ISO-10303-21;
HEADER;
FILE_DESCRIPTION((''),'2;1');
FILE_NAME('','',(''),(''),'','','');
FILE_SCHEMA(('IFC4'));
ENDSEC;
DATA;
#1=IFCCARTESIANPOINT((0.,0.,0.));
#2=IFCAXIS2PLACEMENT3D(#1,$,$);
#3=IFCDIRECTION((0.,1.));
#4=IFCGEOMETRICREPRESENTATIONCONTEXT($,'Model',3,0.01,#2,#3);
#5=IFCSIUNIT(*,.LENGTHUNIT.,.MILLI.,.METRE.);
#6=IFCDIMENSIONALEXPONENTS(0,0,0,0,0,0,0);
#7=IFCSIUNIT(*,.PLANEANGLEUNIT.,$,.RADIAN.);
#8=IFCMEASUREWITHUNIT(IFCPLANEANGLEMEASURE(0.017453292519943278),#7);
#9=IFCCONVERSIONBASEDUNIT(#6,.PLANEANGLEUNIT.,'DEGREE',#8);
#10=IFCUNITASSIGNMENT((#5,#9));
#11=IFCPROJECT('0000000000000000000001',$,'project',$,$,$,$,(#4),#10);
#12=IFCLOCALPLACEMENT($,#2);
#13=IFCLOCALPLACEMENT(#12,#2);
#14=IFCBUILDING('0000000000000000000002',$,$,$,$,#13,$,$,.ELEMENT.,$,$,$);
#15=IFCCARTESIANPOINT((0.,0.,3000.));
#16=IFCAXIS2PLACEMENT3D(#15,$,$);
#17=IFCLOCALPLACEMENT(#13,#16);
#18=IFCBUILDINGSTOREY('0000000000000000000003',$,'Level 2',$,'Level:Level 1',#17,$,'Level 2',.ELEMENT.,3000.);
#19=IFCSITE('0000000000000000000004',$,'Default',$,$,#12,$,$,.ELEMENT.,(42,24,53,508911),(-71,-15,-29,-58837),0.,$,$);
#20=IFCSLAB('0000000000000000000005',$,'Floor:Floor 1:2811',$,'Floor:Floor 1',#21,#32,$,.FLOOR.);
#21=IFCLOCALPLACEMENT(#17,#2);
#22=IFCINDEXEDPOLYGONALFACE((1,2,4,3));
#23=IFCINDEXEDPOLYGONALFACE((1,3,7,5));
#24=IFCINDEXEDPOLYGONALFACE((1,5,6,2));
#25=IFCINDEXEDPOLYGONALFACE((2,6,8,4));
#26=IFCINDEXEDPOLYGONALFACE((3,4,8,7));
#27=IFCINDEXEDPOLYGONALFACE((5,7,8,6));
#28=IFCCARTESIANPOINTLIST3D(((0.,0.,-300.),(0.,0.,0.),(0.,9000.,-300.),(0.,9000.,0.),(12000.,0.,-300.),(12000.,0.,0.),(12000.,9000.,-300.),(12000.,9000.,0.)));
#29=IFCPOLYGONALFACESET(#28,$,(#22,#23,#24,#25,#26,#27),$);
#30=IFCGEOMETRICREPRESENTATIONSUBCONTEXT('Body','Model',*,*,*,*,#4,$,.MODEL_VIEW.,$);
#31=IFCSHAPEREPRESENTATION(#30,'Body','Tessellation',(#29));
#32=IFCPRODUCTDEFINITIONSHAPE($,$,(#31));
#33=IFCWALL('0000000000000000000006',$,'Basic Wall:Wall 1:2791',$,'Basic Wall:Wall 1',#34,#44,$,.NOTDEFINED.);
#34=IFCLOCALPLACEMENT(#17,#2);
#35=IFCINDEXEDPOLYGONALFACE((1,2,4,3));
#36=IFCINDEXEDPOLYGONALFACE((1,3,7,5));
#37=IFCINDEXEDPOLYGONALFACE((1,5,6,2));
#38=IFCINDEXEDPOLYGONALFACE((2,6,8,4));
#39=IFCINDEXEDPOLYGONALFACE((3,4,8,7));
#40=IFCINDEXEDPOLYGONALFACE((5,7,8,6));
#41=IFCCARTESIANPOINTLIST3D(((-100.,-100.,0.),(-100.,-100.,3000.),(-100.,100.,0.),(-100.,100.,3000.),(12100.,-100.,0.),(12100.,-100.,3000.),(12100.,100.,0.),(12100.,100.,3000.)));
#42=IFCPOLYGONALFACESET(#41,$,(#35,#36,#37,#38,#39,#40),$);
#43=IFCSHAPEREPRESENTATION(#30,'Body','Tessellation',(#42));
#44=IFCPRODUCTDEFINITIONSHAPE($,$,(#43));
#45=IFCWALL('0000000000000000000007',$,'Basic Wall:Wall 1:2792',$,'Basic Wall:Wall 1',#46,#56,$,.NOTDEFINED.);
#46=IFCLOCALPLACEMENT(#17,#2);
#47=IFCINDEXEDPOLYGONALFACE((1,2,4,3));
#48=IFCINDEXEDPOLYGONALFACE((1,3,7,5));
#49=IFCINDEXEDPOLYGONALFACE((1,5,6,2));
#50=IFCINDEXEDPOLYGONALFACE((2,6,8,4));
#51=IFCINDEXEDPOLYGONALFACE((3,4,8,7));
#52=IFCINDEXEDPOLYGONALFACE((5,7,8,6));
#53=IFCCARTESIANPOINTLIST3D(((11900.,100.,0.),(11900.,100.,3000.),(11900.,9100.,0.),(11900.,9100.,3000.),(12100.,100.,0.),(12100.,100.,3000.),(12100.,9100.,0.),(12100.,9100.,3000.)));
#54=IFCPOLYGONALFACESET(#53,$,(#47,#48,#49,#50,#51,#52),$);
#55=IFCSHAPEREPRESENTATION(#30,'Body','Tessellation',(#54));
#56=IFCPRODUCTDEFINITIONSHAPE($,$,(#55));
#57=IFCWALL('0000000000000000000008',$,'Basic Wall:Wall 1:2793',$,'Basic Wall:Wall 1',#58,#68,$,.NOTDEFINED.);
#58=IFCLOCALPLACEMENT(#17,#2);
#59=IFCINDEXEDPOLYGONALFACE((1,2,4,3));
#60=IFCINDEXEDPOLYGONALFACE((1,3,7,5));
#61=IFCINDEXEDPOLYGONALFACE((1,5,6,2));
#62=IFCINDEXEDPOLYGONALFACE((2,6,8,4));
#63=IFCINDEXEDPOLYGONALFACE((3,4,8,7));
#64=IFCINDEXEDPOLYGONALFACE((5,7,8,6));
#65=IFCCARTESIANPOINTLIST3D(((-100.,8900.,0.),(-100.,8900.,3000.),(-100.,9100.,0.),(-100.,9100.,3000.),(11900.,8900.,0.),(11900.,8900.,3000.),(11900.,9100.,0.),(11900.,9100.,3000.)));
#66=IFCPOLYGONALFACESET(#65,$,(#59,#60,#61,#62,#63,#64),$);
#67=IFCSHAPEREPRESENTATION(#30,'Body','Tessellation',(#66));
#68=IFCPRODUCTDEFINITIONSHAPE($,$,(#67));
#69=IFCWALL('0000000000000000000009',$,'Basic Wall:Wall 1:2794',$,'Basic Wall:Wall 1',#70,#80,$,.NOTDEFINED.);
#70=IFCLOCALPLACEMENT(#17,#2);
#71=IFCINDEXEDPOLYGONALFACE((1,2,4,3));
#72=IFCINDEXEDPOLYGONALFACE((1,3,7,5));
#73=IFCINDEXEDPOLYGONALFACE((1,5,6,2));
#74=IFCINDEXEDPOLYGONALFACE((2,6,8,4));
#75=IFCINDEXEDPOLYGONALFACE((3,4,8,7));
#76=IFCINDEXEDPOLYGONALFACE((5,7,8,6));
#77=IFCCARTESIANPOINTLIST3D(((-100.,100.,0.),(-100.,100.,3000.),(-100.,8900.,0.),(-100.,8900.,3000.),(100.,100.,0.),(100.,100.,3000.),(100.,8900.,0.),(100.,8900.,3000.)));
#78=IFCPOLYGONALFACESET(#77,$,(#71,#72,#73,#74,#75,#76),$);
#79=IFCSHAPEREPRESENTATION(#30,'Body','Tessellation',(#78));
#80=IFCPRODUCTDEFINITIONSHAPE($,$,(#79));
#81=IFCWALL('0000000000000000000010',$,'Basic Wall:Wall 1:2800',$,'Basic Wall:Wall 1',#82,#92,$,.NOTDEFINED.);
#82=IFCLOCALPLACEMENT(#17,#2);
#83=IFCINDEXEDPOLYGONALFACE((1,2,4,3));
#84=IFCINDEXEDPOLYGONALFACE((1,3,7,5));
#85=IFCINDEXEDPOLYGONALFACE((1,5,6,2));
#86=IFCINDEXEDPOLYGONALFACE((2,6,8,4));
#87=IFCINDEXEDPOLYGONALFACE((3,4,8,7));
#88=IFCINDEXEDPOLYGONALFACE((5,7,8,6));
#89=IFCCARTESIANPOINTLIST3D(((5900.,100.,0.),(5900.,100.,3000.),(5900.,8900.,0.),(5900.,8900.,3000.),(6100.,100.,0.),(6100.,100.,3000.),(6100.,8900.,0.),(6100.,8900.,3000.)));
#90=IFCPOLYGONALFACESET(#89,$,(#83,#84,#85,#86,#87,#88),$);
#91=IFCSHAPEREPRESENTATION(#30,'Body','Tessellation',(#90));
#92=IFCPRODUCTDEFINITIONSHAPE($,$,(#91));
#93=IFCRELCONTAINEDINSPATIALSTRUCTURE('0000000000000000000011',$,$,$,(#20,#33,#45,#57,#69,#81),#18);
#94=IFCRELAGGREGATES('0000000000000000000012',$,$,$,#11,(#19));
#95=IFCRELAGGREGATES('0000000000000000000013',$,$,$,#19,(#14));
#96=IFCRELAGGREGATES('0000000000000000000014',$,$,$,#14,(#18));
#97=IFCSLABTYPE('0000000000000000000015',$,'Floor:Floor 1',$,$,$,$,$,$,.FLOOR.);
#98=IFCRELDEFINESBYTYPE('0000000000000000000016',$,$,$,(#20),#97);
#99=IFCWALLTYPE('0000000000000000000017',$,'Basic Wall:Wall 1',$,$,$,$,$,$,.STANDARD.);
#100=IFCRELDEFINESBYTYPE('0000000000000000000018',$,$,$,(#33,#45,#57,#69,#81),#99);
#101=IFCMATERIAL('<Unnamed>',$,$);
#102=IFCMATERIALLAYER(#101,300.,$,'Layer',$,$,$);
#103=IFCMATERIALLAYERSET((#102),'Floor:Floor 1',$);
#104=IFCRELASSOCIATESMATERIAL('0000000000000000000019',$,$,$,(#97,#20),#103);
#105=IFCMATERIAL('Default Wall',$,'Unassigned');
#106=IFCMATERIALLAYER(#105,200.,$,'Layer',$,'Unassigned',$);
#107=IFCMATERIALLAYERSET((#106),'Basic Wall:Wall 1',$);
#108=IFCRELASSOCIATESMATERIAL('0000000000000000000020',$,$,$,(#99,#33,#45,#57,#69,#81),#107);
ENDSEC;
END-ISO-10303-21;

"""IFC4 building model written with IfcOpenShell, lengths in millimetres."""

from ifc_helpers import new_model, entity, si_unit, converted_unit, direction, frame, frame_2d, origin, origin_2d_with_axis, place, context, subcontext, project, spatial, rectangle, extrude, material, layer, layer_set, layer_usage, type_object, element, save


model = new_model("IFC4")

# Units and contexts
model_context = context("Model", 3, precision=0.01, world=origin(), true_north=direction((0.0, 1.0)))
body_context = subcontext(model_context, "Body", "Model", "MODEL_VIEW")
ifc_project = project(units=[si_unit("LENGTHUNIT", "METRE", prefix="MILLI"), converted_unit("PLANEANGLEUNIT", "DEGREE", entity("IfcPlaneAngleMeasure", 0.017453292519943278), si_unit("PLANEANGLEUNIT", "RADIAN"), dimensions=[0, 0, 0, 0, 0, 0, 0])], contexts=[model_context])

# Site, building, storey
site_placement = place(None, origin())
site = spatial("IfcSite", under=ifc_project, at=site_placement, Name="Default", CompositionType="ELEMENT", RefLatitude=(42, 24, 53, 508911), RefLongitude=(-71, -15, -29, -58837), RefElevation=0.0)
building_placement = place(site_placement, origin())
building = spatial("IfcBuilding", under=site, at=building_placement, CompositionType="ELEMENT")
storey_placement = place(building_placement, frame((0.0, 0.0, 3000.0)))
storey = spatial("IfcBuildingStorey", under=building, at=storey_placement, Name="Level 2", ObjectType="Level:Level 1", LongName="Level 2", CompositionType="ELEMENT", Elevation=3000.0)

# Slab
ifc_material_1 = material(Name="<Unnamed>")
ifc_layer_1 = layer(ifc_material_1, 300.0, Name="Layer")
ifc_layer_set_1 = layer_set([ifc_layer_1], Name="Floor:Floor 1")
ifc_layer_usage_1 = layer_usage(ifc_layer_set_1, "AXIS3", "POSITIVE", 0.0)
slab_type = type_object("IfcSlabType", Name="Floor:Floor 1", PredefinedType="FLOOR", material=ifc_layer_set_1)
slab_placement = place(storey_placement, origin())
element("IfcSlab", 1, at=slab_placement, inside=storey, type_object=slab_type, material=ifc_layer_usage_1, Name="Floor:Floor 1:2811", ObjectType="Floor:Floor 1", PredefinedType="FLOOR", context=body_context, shape_type="SweptSolid", body=[
    extrude(rectangle(XDim=9000.0, YDim=12000.0, at=origin_2d_with_axis()), frame((6000.0, 4500.0, 0.0), z_axis=(0.0, 0.0, -1.0), x_axis=(0.0, 1.0, 0.0)), (0.0, 0.0, 1.0), 300.0),
])

# Walls
ifc_material_2 = material(Name="Default Wall", Category="Unassigned")
ifc_layer_2 = layer(ifc_material_2, 200.0, Name="Layer", Category="Unassigned")
ifc_layer_set_2 = layer_set([ifc_layer_2], Name="Basic Wall:Wall 1")
ifc_layer_usage_2 = layer_usage(ifc_layer_set_2, "AXIS2", "NEGATIVE", 100.0)
wall_type = type_object("IfcWallType", Name="Basic Wall:Wall 1", PredefinedType="STANDARD", material=ifc_layer_set_2)
wall_1_placement = place(storey_placement, frame((-100.0, 0.0, 0.0)))
element("IfcWall", 2, at=wall_1_placement, inside=storey, type_object=wall_type, material=ifc_layer_usage_2, Name="Basic Wall:Wall 1:2791", ObjectType="Basic Wall:Wall 1", PredefinedType="NOTDEFINED", context=body_context, shape_type="SweptSolid", body=[
    extrude(rectangle(XDim=12200.0, YDim=200.0, at=frame_2d((6100.0, 0.0), x_axis=(-1.0, 0.0))), origin(), (0.0, 0.0, 1.0), 3000.0),
])
ifc_layer_usage_3 = layer_usage(ifc_layer_set_2, "AXIS2", "NEGATIVE", 100.0)
wall_2_placement = place(storey_placement, frame((12000.0, 100.0, 0.0), z_axis=(0.0, 0.0, 1.0), x_axis=(0.0, 1.0, 0.0)))
element("IfcWall", 3, at=wall_2_placement, inside=storey, type_object=wall_type, material=ifc_layer_usage_3, Name="Basic Wall:Wall 1:2792", ObjectType="Basic Wall:Wall 1", PredefinedType="NOTDEFINED", context=body_context, shape_type="SweptSolid", body=[
    extrude(rectangle(XDim=9000.0, YDim=200.0, at=frame_2d((4500.0, 0.0), x_axis=(-1.0, 0.0))), origin(), (0.0, 0.0, 1.0), 3000.0),
])
ifc_layer_usage_4 = layer_usage(ifc_layer_set_2, "AXIS2", "NEGATIVE", 100.0)
wall_3_placement = place(storey_placement, frame((11900.0, 9000.0, 0.0), z_axis=(0.0, 0.0, 1.0), x_axis=(-1.0, 0.0, 0.0)))
element("IfcWall", 4, at=wall_3_placement, inside=storey, type_object=wall_type, material=ifc_layer_usage_4, Name="Basic Wall:Wall 1:2793", ObjectType="Basic Wall:Wall 1", PredefinedType="NOTDEFINED", context=body_context, shape_type="SweptSolid", body=[
    extrude(rectangle(XDim=12000.0, YDim=200.0, at=frame_2d((6000.0, 0.0), x_axis=(-1.0, 0.0))), origin(), (0.0, 0.0, 1.0), 3000.0),
])
ifc_layer_usage_5 = layer_usage(ifc_layer_set_2, "AXIS2", "NEGATIVE", 100.0)
wall_4_placement = place(storey_placement, frame((0.0, 8900.0, 0.0), z_axis=(0.0, 0.0, 1.0), x_axis=(0.0, -1.0, 0.0)))
element("IfcWall", 5, at=wall_4_placement, inside=storey, type_object=wall_type, material=ifc_layer_usage_5, Name="Basic Wall:Wall 1:2794", ObjectType="Basic Wall:Wall 1", PredefinedType="NOTDEFINED", context=body_context, shape_type="SweptSolid", body=[
    extrude(rectangle(XDim=8800.0, YDim=200.0, at=frame_2d((4400.0, 0.0), x_axis=(-1.0, 0.0))), origin(), (0.0, 0.0, 1.0), 3000.0),
])
ifc_layer_usage_6 = layer_usage(ifc_layer_set_2, "AXIS2", "NEGATIVE", 100.0)
wall_5_placement = place(storey_placement, frame((6000.0, 100.0, 0.0), z_axis=(0.0, 0.0, 1.0), x_axis=(0.0, 1.0, 0.0)))
element("IfcWall", 6, at=wall_5_placement, inside=storey, type_object=wall_type, material=ifc_layer_usage_6, Name="Basic Wall:Wall 1:2800", ObjectType="Basic Wall:Wall 1", PredefinedType="NOTDEFINED", context=body_context, shape_type="SweptSolid", body=[
    extrude(rectangle(XDim=8800.0, YDim=200.0, at=frame_2d((4400.0, 0.0), x_axis=(-1.0, 0.0))), origin(), (0.0, 0.0, 1.0), 3000.0),
])

save(model, "model.ifc")
